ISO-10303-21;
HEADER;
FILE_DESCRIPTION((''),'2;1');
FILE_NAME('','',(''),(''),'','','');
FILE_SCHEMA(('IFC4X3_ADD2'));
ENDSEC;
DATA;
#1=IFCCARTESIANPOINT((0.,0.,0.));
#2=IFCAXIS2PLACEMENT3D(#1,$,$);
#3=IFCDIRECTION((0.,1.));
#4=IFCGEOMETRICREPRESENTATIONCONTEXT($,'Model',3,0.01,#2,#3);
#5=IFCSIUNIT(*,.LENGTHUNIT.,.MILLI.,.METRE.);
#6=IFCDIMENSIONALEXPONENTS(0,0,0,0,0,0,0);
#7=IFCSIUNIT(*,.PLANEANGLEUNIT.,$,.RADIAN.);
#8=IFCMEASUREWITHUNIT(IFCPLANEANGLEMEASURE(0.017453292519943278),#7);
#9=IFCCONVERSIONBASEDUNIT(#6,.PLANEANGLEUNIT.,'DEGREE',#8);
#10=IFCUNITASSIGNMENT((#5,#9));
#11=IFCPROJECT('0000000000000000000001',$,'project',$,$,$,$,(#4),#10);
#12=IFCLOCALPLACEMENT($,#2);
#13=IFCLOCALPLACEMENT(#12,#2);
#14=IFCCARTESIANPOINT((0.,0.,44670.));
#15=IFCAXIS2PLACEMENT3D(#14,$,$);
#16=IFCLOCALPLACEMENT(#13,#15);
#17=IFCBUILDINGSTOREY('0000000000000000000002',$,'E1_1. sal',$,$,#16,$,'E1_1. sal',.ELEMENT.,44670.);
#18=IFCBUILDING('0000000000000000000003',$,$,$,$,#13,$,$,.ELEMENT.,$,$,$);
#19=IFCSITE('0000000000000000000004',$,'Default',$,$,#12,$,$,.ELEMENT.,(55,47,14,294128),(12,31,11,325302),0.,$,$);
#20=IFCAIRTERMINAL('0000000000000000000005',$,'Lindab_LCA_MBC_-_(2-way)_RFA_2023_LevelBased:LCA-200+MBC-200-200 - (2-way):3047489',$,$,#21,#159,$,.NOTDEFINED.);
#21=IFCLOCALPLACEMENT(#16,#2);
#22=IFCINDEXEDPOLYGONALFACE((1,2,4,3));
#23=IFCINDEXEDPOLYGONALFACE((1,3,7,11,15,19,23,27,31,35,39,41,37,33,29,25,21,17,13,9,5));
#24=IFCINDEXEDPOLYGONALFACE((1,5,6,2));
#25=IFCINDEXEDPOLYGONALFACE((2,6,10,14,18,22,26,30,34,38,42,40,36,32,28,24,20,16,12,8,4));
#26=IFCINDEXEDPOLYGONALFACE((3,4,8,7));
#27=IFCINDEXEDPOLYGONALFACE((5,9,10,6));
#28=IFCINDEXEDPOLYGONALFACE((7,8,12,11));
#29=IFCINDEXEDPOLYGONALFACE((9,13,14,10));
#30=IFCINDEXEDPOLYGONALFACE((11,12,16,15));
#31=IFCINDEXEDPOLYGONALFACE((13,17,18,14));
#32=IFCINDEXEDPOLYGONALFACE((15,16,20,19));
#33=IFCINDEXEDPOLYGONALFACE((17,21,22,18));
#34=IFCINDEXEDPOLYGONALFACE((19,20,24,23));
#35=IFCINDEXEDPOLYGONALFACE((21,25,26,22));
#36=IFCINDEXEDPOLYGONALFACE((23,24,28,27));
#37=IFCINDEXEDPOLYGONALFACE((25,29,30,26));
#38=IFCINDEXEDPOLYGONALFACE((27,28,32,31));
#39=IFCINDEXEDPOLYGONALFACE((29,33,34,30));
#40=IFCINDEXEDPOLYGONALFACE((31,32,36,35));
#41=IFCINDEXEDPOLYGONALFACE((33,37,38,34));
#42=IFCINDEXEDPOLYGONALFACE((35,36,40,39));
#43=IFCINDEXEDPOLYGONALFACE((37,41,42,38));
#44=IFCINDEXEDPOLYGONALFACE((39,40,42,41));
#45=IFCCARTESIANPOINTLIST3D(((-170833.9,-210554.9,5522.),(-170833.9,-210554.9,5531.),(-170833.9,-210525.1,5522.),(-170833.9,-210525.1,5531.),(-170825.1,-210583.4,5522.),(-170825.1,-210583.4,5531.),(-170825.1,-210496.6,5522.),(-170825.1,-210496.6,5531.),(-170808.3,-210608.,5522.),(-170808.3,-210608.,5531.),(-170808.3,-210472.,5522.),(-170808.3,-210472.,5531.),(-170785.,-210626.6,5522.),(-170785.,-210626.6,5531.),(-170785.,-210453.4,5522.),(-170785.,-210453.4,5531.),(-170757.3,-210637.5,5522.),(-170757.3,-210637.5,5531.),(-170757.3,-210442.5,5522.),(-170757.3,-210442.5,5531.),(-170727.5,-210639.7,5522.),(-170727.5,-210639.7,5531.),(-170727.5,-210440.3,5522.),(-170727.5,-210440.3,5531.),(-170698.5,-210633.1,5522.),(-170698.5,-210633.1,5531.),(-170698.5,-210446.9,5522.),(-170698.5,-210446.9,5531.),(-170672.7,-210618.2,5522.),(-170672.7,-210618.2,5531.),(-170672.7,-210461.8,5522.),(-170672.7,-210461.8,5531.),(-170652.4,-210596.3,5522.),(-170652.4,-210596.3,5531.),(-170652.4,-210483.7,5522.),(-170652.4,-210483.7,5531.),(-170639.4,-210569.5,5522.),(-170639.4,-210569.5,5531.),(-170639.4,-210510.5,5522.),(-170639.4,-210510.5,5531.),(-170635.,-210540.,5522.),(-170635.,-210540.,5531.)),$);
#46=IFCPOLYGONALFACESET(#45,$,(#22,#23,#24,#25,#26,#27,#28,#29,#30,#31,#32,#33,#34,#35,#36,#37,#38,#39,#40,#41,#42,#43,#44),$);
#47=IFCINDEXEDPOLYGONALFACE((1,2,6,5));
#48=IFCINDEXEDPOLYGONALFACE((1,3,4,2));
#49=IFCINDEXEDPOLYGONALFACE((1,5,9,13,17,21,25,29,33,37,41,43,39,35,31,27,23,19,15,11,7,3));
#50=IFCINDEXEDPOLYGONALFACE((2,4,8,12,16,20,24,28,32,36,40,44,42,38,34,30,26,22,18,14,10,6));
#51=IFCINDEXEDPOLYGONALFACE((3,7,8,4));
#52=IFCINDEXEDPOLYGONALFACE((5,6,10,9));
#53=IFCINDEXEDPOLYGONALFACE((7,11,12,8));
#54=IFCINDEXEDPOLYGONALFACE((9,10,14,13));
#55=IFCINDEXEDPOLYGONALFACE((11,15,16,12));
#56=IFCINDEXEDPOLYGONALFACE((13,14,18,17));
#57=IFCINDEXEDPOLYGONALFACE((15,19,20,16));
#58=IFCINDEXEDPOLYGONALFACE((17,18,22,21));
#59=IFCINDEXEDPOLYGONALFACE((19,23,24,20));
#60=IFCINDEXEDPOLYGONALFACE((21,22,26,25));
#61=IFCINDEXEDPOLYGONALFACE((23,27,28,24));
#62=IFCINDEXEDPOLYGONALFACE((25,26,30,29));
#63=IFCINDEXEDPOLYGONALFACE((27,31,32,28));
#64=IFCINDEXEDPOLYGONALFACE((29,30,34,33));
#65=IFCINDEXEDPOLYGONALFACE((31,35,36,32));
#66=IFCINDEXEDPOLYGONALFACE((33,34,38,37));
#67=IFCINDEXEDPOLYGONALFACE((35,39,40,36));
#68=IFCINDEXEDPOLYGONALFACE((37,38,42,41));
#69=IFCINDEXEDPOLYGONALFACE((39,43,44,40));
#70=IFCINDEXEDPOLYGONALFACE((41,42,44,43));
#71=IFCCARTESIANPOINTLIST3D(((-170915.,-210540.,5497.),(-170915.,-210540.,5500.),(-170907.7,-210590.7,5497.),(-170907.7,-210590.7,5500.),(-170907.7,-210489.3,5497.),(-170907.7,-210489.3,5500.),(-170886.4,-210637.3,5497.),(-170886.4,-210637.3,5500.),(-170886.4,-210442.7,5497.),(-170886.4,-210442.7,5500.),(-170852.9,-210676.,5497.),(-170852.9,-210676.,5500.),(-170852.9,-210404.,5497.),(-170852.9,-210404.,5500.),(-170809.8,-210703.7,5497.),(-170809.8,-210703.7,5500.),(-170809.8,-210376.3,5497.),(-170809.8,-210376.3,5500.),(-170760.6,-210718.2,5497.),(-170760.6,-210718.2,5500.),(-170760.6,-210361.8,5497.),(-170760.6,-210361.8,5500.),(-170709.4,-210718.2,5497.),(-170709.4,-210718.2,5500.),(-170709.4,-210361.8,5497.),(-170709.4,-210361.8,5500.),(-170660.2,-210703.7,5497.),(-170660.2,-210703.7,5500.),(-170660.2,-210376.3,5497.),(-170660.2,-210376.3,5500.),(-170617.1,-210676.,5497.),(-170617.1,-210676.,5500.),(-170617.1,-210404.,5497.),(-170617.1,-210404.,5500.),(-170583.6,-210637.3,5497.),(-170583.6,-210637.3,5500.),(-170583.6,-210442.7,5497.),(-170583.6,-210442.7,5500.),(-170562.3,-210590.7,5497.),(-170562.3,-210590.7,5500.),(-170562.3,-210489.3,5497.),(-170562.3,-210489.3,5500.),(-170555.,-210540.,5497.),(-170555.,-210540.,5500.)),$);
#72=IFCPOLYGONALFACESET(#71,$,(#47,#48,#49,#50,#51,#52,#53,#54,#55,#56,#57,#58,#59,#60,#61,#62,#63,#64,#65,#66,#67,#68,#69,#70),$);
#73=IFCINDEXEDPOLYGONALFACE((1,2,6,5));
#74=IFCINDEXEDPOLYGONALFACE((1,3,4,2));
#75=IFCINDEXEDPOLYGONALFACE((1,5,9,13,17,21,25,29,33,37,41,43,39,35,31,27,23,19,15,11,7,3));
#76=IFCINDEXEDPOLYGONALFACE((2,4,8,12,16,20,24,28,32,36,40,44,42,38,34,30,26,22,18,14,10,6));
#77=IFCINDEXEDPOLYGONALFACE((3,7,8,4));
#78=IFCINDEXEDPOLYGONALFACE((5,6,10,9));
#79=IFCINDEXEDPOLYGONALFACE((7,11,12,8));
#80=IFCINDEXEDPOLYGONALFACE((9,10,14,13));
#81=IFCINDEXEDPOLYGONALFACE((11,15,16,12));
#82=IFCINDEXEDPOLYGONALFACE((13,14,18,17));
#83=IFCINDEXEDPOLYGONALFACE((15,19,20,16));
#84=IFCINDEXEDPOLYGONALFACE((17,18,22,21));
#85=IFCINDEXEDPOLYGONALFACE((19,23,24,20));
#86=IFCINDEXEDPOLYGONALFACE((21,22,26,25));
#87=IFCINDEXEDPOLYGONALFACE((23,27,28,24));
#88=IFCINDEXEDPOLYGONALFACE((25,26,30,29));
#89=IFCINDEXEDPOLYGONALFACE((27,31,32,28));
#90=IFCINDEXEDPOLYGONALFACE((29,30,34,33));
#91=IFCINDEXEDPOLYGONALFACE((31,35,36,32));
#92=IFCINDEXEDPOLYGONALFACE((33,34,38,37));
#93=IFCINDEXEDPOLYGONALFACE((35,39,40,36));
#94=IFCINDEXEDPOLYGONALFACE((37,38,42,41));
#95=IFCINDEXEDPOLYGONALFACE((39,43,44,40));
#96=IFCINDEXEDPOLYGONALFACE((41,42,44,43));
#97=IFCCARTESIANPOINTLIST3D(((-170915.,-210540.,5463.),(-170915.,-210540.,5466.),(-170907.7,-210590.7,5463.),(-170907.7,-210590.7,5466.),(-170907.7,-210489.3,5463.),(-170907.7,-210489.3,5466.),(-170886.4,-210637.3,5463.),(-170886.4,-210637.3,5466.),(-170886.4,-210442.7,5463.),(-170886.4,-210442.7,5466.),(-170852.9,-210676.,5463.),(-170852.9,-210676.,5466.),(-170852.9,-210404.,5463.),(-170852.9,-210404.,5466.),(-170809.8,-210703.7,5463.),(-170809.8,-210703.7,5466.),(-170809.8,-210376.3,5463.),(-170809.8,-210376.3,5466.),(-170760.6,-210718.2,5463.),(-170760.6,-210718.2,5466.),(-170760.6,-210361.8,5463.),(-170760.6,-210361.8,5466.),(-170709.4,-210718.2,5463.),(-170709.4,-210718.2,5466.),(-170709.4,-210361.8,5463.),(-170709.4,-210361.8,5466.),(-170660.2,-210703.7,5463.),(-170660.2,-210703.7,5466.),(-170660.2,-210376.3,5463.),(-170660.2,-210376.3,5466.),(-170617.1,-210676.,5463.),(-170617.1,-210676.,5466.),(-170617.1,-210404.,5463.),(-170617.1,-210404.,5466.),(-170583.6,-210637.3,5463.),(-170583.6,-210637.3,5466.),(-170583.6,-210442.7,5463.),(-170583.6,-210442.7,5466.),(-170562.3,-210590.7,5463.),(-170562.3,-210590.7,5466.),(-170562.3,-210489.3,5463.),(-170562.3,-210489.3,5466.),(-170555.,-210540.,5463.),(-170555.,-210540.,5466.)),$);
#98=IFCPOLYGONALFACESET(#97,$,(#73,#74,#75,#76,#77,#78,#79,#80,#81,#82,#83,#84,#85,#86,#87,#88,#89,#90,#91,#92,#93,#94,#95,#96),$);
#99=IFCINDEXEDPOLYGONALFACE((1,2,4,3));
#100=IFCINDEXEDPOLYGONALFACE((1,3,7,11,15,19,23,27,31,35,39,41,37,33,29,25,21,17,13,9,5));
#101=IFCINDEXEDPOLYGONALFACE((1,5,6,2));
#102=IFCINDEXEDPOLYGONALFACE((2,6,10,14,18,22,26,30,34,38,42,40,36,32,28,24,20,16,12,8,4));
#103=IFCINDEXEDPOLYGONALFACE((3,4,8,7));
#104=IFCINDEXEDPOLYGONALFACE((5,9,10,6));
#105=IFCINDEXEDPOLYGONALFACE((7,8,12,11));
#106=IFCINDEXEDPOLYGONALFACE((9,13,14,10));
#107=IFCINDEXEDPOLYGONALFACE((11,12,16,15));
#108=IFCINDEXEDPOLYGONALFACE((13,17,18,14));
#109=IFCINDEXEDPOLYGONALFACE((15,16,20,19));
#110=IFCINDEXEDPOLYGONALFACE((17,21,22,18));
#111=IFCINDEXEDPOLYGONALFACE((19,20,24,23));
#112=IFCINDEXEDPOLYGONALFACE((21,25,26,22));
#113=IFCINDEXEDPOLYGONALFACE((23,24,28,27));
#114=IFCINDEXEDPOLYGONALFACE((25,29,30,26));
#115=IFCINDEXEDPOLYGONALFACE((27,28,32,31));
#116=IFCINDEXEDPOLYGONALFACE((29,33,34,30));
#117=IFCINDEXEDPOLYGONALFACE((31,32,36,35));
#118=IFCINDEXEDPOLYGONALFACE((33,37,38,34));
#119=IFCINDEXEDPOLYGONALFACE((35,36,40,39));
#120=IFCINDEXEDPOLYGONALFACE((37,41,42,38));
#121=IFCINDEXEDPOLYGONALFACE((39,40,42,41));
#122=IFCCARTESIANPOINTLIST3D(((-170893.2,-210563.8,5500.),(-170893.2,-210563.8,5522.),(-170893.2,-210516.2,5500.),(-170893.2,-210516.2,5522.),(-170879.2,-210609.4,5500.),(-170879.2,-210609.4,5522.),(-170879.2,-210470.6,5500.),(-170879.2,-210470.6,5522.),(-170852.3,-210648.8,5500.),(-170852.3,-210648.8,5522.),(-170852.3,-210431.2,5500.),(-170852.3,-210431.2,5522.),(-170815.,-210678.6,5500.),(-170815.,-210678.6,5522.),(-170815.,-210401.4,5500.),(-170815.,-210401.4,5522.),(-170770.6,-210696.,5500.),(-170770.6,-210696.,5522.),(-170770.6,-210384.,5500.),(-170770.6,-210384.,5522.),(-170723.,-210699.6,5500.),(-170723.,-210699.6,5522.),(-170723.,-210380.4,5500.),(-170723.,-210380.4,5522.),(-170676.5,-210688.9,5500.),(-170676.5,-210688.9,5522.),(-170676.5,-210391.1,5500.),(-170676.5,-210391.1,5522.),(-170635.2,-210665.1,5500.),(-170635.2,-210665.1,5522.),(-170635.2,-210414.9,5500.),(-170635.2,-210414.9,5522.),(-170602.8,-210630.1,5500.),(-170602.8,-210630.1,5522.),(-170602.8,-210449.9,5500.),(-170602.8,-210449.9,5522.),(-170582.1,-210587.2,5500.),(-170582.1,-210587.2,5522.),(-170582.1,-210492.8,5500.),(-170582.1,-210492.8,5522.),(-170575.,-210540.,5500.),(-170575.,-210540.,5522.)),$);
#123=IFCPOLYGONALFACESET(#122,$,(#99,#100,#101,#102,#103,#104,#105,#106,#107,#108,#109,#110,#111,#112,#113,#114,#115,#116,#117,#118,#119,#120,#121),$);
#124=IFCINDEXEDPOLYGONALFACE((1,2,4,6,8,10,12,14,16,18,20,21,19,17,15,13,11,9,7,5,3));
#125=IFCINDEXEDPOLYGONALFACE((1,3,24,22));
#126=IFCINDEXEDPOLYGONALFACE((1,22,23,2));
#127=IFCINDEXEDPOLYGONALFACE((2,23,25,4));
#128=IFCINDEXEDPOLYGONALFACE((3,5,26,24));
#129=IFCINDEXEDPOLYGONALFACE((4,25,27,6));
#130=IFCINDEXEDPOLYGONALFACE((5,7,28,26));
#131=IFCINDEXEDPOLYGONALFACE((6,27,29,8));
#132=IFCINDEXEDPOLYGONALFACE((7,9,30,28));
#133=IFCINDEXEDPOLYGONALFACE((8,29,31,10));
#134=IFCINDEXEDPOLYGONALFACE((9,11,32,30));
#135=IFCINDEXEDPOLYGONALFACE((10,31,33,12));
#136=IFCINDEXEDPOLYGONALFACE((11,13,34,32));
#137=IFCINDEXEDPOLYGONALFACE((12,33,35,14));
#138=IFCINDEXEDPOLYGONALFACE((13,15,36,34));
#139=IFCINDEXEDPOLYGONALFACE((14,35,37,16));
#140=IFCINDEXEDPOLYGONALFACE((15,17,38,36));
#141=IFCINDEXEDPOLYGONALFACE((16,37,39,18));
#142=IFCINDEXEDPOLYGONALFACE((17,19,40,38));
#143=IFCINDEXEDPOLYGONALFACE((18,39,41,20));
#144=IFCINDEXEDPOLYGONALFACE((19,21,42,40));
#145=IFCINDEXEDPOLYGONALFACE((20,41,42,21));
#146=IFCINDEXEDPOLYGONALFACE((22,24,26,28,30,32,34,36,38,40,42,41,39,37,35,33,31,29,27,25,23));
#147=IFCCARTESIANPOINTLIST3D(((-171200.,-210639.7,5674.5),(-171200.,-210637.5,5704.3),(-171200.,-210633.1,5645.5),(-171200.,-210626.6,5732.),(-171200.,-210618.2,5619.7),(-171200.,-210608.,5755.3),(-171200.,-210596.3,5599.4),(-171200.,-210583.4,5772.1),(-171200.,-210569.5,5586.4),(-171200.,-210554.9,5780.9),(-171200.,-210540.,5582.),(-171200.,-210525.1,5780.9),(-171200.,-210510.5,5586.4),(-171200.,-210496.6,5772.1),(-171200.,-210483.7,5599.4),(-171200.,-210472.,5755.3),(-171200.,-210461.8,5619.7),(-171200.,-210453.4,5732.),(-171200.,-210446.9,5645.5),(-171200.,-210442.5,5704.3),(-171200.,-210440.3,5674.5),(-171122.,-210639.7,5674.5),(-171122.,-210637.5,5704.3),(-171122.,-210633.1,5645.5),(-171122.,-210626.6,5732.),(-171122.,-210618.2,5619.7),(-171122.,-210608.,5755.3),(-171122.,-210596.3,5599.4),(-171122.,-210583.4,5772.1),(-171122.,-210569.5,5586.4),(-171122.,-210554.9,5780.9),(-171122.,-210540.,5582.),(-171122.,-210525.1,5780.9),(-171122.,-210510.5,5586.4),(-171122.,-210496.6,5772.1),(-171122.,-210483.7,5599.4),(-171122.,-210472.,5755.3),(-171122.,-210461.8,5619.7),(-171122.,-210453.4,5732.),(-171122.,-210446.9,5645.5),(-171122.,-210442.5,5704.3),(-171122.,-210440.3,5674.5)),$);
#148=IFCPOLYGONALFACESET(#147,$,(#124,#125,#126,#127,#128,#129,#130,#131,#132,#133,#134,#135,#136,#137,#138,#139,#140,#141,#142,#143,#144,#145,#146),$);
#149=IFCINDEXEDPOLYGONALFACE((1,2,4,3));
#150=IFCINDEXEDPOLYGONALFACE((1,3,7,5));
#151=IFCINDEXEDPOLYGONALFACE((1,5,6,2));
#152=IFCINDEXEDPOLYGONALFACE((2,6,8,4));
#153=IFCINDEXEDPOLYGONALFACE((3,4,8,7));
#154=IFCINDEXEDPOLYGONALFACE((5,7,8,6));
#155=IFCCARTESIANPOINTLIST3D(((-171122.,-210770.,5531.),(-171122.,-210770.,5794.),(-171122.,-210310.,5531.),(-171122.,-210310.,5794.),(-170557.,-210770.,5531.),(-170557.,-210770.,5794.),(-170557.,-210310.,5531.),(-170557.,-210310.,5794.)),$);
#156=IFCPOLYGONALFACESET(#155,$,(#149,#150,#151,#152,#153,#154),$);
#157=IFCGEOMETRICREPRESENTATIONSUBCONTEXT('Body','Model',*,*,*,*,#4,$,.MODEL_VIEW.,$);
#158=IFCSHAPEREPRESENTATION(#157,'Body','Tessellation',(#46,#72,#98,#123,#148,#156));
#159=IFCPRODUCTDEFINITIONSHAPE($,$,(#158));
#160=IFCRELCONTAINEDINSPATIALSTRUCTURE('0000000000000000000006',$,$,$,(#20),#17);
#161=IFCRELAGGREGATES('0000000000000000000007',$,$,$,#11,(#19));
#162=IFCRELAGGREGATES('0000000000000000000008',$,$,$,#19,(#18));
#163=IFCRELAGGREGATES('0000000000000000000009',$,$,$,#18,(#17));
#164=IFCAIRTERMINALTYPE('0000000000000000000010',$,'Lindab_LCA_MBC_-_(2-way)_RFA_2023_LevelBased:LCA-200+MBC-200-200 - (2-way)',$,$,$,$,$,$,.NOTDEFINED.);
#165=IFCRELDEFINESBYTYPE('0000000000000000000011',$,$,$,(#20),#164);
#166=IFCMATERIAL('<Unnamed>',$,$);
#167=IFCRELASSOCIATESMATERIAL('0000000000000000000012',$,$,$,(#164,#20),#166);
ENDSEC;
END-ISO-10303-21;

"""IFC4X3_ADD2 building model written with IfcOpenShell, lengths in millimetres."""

from ifc_helpers import new_model, entity, si_unit, converted_unit, direction, frame, frame_2d, origin, origin_2d_with_axis, place, context, subcontext, project, spatial, rectangle, circle, extrude, source, transform, mapped, material, type_object, type_shapes, element, save


model = new_model("IFC4X3_ADD2")

# Units and contexts
model_context = context("Model", 3, precision=0.01, world=origin(), true_north=direction((0.0, 1.0)))
body_context = subcontext(model_context, "Body", "Model", "MODEL_VIEW")
ifc_project = project(units=[si_unit("LENGTHUNIT", "METRE", prefix="MILLI"), converted_unit("PLANEANGLEUNIT", "DEGREE", entity("IfcPlaneAngleMeasure", 0.017453292519943278), si_unit("PLANEANGLEUNIT", "RADIAN"), dimensions=[0, 0, 0, 0, 0, 0, 0])], contexts=[model_context])

# Site, building, storey
site_placement = place(None, origin())
site = spatial("IfcSite", under=ifc_project, at=site_placement, Name="Default", CompositionType="ELEMENT", RefLatitude=(55, 47, 14, 294128), RefLongitude=(12, 31, 11, 325302), RefElevation=0.0)
building_placement = place(site_placement, origin())
building = spatial("IfcBuilding", under=site, at=building_placement, CompositionType="ELEMENT")
storey_placement = place(building_placement, frame((0.0, 0.0, 44670.0)))
storey = spatial("IfcBuildingStorey", under=building, at=storey_placement, Name="E1_1. sal", LongName="E1_1. sal", CompositionType="ELEMENT", Elevation=44670.0)

# Air terminal
ifc_material_1 = material(Name="<Unnamed>")
air_terminal_type_1 = type_object("IfcAirTerminalType", Name="Lindab_LCA_MBC_-_(2-way)_RFA_2023_LevelBased:LCA-200+MBC-200-200 - (2-way)", PredefinedType="NOTDEFINED", material=ifc_material_1)
shared_shape_1 = source(origin(), body_context, "Body", "SweptSolid", [
    extrude(circle(Radius=100.0, at=frame_2d((0.0, 0.0), x_axis=(1.0, 0.0))), frame((0.0, 0.0, 22.0)), (0.0, 0.0, 1.0), 9.0),
    extrude(circle(Radius=180.0, at=frame_2d((0.0, 0.0), x_axis=(1.0, 0.0))), frame((0.0, 0.0, -3.0)), (0.0, 0.0, 1.0), 3.0),
    extrude(circle(Radius=180.0, at=frame_2d((0.0, 0.0), x_axis=(1.0, 0.0))), frame((0.0, 0.0, -37.0)), (0.0, 0.0, 1.0), 3.0),
    extrude(circle(Radius=160.0, at=frame_2d((0.0, 0.0), x_axis=(1.0, 0.0))), origin(), (0.0, 0.0, 1.0), 22.0),
    extrude(circle(Radius=100.0, at=frame_2d((0.0, 0.0), x_axis=(1.0, 0.0))), frame((-465.0, 0.0, 182.0), z_axis=(1.0, 0.0, 0.0), x_axis=(0.0, 0.0, -1.0)), (0.0, 0.0, 1.0), 78.0),
    extrude(rectangle(XDim=460.0, YDim=565.0, at=origin_2d_with_axis()), frame((-104.5, 0.0, 31.0), z_axis=(0.0, 0.0, 1.0), x_axis=(0.0, -1.0, 0.0)), (0.0, 0.0, 1.0), 263.0),
])
type_shapes(air_terminal_type_1, [shared_shape_1])
for number, where, name in (
    (1, (-170735.0, -210540.0, 5500.0), "Lindab_LCA_MBC_-_(2-way)_RFA_2023_LevelBased:LCA-200+MBC-200-200 - (2-way):3047489"),
):
    element("IfcAirTerminal", number, at=place(storey_placement, frame(where)), inside=storey, type_object=air_terminal_type_1, material=ifc_material_1, Name=name, PredefinedType="NOTDEFINED", context=body_context, shape_type="MappedRepresentation", body=[
        mapped(shared_shape_1, transform((0.0, 0.0, 0.0), scale=1.0)),
    ])

save(model, "model.ifc")
